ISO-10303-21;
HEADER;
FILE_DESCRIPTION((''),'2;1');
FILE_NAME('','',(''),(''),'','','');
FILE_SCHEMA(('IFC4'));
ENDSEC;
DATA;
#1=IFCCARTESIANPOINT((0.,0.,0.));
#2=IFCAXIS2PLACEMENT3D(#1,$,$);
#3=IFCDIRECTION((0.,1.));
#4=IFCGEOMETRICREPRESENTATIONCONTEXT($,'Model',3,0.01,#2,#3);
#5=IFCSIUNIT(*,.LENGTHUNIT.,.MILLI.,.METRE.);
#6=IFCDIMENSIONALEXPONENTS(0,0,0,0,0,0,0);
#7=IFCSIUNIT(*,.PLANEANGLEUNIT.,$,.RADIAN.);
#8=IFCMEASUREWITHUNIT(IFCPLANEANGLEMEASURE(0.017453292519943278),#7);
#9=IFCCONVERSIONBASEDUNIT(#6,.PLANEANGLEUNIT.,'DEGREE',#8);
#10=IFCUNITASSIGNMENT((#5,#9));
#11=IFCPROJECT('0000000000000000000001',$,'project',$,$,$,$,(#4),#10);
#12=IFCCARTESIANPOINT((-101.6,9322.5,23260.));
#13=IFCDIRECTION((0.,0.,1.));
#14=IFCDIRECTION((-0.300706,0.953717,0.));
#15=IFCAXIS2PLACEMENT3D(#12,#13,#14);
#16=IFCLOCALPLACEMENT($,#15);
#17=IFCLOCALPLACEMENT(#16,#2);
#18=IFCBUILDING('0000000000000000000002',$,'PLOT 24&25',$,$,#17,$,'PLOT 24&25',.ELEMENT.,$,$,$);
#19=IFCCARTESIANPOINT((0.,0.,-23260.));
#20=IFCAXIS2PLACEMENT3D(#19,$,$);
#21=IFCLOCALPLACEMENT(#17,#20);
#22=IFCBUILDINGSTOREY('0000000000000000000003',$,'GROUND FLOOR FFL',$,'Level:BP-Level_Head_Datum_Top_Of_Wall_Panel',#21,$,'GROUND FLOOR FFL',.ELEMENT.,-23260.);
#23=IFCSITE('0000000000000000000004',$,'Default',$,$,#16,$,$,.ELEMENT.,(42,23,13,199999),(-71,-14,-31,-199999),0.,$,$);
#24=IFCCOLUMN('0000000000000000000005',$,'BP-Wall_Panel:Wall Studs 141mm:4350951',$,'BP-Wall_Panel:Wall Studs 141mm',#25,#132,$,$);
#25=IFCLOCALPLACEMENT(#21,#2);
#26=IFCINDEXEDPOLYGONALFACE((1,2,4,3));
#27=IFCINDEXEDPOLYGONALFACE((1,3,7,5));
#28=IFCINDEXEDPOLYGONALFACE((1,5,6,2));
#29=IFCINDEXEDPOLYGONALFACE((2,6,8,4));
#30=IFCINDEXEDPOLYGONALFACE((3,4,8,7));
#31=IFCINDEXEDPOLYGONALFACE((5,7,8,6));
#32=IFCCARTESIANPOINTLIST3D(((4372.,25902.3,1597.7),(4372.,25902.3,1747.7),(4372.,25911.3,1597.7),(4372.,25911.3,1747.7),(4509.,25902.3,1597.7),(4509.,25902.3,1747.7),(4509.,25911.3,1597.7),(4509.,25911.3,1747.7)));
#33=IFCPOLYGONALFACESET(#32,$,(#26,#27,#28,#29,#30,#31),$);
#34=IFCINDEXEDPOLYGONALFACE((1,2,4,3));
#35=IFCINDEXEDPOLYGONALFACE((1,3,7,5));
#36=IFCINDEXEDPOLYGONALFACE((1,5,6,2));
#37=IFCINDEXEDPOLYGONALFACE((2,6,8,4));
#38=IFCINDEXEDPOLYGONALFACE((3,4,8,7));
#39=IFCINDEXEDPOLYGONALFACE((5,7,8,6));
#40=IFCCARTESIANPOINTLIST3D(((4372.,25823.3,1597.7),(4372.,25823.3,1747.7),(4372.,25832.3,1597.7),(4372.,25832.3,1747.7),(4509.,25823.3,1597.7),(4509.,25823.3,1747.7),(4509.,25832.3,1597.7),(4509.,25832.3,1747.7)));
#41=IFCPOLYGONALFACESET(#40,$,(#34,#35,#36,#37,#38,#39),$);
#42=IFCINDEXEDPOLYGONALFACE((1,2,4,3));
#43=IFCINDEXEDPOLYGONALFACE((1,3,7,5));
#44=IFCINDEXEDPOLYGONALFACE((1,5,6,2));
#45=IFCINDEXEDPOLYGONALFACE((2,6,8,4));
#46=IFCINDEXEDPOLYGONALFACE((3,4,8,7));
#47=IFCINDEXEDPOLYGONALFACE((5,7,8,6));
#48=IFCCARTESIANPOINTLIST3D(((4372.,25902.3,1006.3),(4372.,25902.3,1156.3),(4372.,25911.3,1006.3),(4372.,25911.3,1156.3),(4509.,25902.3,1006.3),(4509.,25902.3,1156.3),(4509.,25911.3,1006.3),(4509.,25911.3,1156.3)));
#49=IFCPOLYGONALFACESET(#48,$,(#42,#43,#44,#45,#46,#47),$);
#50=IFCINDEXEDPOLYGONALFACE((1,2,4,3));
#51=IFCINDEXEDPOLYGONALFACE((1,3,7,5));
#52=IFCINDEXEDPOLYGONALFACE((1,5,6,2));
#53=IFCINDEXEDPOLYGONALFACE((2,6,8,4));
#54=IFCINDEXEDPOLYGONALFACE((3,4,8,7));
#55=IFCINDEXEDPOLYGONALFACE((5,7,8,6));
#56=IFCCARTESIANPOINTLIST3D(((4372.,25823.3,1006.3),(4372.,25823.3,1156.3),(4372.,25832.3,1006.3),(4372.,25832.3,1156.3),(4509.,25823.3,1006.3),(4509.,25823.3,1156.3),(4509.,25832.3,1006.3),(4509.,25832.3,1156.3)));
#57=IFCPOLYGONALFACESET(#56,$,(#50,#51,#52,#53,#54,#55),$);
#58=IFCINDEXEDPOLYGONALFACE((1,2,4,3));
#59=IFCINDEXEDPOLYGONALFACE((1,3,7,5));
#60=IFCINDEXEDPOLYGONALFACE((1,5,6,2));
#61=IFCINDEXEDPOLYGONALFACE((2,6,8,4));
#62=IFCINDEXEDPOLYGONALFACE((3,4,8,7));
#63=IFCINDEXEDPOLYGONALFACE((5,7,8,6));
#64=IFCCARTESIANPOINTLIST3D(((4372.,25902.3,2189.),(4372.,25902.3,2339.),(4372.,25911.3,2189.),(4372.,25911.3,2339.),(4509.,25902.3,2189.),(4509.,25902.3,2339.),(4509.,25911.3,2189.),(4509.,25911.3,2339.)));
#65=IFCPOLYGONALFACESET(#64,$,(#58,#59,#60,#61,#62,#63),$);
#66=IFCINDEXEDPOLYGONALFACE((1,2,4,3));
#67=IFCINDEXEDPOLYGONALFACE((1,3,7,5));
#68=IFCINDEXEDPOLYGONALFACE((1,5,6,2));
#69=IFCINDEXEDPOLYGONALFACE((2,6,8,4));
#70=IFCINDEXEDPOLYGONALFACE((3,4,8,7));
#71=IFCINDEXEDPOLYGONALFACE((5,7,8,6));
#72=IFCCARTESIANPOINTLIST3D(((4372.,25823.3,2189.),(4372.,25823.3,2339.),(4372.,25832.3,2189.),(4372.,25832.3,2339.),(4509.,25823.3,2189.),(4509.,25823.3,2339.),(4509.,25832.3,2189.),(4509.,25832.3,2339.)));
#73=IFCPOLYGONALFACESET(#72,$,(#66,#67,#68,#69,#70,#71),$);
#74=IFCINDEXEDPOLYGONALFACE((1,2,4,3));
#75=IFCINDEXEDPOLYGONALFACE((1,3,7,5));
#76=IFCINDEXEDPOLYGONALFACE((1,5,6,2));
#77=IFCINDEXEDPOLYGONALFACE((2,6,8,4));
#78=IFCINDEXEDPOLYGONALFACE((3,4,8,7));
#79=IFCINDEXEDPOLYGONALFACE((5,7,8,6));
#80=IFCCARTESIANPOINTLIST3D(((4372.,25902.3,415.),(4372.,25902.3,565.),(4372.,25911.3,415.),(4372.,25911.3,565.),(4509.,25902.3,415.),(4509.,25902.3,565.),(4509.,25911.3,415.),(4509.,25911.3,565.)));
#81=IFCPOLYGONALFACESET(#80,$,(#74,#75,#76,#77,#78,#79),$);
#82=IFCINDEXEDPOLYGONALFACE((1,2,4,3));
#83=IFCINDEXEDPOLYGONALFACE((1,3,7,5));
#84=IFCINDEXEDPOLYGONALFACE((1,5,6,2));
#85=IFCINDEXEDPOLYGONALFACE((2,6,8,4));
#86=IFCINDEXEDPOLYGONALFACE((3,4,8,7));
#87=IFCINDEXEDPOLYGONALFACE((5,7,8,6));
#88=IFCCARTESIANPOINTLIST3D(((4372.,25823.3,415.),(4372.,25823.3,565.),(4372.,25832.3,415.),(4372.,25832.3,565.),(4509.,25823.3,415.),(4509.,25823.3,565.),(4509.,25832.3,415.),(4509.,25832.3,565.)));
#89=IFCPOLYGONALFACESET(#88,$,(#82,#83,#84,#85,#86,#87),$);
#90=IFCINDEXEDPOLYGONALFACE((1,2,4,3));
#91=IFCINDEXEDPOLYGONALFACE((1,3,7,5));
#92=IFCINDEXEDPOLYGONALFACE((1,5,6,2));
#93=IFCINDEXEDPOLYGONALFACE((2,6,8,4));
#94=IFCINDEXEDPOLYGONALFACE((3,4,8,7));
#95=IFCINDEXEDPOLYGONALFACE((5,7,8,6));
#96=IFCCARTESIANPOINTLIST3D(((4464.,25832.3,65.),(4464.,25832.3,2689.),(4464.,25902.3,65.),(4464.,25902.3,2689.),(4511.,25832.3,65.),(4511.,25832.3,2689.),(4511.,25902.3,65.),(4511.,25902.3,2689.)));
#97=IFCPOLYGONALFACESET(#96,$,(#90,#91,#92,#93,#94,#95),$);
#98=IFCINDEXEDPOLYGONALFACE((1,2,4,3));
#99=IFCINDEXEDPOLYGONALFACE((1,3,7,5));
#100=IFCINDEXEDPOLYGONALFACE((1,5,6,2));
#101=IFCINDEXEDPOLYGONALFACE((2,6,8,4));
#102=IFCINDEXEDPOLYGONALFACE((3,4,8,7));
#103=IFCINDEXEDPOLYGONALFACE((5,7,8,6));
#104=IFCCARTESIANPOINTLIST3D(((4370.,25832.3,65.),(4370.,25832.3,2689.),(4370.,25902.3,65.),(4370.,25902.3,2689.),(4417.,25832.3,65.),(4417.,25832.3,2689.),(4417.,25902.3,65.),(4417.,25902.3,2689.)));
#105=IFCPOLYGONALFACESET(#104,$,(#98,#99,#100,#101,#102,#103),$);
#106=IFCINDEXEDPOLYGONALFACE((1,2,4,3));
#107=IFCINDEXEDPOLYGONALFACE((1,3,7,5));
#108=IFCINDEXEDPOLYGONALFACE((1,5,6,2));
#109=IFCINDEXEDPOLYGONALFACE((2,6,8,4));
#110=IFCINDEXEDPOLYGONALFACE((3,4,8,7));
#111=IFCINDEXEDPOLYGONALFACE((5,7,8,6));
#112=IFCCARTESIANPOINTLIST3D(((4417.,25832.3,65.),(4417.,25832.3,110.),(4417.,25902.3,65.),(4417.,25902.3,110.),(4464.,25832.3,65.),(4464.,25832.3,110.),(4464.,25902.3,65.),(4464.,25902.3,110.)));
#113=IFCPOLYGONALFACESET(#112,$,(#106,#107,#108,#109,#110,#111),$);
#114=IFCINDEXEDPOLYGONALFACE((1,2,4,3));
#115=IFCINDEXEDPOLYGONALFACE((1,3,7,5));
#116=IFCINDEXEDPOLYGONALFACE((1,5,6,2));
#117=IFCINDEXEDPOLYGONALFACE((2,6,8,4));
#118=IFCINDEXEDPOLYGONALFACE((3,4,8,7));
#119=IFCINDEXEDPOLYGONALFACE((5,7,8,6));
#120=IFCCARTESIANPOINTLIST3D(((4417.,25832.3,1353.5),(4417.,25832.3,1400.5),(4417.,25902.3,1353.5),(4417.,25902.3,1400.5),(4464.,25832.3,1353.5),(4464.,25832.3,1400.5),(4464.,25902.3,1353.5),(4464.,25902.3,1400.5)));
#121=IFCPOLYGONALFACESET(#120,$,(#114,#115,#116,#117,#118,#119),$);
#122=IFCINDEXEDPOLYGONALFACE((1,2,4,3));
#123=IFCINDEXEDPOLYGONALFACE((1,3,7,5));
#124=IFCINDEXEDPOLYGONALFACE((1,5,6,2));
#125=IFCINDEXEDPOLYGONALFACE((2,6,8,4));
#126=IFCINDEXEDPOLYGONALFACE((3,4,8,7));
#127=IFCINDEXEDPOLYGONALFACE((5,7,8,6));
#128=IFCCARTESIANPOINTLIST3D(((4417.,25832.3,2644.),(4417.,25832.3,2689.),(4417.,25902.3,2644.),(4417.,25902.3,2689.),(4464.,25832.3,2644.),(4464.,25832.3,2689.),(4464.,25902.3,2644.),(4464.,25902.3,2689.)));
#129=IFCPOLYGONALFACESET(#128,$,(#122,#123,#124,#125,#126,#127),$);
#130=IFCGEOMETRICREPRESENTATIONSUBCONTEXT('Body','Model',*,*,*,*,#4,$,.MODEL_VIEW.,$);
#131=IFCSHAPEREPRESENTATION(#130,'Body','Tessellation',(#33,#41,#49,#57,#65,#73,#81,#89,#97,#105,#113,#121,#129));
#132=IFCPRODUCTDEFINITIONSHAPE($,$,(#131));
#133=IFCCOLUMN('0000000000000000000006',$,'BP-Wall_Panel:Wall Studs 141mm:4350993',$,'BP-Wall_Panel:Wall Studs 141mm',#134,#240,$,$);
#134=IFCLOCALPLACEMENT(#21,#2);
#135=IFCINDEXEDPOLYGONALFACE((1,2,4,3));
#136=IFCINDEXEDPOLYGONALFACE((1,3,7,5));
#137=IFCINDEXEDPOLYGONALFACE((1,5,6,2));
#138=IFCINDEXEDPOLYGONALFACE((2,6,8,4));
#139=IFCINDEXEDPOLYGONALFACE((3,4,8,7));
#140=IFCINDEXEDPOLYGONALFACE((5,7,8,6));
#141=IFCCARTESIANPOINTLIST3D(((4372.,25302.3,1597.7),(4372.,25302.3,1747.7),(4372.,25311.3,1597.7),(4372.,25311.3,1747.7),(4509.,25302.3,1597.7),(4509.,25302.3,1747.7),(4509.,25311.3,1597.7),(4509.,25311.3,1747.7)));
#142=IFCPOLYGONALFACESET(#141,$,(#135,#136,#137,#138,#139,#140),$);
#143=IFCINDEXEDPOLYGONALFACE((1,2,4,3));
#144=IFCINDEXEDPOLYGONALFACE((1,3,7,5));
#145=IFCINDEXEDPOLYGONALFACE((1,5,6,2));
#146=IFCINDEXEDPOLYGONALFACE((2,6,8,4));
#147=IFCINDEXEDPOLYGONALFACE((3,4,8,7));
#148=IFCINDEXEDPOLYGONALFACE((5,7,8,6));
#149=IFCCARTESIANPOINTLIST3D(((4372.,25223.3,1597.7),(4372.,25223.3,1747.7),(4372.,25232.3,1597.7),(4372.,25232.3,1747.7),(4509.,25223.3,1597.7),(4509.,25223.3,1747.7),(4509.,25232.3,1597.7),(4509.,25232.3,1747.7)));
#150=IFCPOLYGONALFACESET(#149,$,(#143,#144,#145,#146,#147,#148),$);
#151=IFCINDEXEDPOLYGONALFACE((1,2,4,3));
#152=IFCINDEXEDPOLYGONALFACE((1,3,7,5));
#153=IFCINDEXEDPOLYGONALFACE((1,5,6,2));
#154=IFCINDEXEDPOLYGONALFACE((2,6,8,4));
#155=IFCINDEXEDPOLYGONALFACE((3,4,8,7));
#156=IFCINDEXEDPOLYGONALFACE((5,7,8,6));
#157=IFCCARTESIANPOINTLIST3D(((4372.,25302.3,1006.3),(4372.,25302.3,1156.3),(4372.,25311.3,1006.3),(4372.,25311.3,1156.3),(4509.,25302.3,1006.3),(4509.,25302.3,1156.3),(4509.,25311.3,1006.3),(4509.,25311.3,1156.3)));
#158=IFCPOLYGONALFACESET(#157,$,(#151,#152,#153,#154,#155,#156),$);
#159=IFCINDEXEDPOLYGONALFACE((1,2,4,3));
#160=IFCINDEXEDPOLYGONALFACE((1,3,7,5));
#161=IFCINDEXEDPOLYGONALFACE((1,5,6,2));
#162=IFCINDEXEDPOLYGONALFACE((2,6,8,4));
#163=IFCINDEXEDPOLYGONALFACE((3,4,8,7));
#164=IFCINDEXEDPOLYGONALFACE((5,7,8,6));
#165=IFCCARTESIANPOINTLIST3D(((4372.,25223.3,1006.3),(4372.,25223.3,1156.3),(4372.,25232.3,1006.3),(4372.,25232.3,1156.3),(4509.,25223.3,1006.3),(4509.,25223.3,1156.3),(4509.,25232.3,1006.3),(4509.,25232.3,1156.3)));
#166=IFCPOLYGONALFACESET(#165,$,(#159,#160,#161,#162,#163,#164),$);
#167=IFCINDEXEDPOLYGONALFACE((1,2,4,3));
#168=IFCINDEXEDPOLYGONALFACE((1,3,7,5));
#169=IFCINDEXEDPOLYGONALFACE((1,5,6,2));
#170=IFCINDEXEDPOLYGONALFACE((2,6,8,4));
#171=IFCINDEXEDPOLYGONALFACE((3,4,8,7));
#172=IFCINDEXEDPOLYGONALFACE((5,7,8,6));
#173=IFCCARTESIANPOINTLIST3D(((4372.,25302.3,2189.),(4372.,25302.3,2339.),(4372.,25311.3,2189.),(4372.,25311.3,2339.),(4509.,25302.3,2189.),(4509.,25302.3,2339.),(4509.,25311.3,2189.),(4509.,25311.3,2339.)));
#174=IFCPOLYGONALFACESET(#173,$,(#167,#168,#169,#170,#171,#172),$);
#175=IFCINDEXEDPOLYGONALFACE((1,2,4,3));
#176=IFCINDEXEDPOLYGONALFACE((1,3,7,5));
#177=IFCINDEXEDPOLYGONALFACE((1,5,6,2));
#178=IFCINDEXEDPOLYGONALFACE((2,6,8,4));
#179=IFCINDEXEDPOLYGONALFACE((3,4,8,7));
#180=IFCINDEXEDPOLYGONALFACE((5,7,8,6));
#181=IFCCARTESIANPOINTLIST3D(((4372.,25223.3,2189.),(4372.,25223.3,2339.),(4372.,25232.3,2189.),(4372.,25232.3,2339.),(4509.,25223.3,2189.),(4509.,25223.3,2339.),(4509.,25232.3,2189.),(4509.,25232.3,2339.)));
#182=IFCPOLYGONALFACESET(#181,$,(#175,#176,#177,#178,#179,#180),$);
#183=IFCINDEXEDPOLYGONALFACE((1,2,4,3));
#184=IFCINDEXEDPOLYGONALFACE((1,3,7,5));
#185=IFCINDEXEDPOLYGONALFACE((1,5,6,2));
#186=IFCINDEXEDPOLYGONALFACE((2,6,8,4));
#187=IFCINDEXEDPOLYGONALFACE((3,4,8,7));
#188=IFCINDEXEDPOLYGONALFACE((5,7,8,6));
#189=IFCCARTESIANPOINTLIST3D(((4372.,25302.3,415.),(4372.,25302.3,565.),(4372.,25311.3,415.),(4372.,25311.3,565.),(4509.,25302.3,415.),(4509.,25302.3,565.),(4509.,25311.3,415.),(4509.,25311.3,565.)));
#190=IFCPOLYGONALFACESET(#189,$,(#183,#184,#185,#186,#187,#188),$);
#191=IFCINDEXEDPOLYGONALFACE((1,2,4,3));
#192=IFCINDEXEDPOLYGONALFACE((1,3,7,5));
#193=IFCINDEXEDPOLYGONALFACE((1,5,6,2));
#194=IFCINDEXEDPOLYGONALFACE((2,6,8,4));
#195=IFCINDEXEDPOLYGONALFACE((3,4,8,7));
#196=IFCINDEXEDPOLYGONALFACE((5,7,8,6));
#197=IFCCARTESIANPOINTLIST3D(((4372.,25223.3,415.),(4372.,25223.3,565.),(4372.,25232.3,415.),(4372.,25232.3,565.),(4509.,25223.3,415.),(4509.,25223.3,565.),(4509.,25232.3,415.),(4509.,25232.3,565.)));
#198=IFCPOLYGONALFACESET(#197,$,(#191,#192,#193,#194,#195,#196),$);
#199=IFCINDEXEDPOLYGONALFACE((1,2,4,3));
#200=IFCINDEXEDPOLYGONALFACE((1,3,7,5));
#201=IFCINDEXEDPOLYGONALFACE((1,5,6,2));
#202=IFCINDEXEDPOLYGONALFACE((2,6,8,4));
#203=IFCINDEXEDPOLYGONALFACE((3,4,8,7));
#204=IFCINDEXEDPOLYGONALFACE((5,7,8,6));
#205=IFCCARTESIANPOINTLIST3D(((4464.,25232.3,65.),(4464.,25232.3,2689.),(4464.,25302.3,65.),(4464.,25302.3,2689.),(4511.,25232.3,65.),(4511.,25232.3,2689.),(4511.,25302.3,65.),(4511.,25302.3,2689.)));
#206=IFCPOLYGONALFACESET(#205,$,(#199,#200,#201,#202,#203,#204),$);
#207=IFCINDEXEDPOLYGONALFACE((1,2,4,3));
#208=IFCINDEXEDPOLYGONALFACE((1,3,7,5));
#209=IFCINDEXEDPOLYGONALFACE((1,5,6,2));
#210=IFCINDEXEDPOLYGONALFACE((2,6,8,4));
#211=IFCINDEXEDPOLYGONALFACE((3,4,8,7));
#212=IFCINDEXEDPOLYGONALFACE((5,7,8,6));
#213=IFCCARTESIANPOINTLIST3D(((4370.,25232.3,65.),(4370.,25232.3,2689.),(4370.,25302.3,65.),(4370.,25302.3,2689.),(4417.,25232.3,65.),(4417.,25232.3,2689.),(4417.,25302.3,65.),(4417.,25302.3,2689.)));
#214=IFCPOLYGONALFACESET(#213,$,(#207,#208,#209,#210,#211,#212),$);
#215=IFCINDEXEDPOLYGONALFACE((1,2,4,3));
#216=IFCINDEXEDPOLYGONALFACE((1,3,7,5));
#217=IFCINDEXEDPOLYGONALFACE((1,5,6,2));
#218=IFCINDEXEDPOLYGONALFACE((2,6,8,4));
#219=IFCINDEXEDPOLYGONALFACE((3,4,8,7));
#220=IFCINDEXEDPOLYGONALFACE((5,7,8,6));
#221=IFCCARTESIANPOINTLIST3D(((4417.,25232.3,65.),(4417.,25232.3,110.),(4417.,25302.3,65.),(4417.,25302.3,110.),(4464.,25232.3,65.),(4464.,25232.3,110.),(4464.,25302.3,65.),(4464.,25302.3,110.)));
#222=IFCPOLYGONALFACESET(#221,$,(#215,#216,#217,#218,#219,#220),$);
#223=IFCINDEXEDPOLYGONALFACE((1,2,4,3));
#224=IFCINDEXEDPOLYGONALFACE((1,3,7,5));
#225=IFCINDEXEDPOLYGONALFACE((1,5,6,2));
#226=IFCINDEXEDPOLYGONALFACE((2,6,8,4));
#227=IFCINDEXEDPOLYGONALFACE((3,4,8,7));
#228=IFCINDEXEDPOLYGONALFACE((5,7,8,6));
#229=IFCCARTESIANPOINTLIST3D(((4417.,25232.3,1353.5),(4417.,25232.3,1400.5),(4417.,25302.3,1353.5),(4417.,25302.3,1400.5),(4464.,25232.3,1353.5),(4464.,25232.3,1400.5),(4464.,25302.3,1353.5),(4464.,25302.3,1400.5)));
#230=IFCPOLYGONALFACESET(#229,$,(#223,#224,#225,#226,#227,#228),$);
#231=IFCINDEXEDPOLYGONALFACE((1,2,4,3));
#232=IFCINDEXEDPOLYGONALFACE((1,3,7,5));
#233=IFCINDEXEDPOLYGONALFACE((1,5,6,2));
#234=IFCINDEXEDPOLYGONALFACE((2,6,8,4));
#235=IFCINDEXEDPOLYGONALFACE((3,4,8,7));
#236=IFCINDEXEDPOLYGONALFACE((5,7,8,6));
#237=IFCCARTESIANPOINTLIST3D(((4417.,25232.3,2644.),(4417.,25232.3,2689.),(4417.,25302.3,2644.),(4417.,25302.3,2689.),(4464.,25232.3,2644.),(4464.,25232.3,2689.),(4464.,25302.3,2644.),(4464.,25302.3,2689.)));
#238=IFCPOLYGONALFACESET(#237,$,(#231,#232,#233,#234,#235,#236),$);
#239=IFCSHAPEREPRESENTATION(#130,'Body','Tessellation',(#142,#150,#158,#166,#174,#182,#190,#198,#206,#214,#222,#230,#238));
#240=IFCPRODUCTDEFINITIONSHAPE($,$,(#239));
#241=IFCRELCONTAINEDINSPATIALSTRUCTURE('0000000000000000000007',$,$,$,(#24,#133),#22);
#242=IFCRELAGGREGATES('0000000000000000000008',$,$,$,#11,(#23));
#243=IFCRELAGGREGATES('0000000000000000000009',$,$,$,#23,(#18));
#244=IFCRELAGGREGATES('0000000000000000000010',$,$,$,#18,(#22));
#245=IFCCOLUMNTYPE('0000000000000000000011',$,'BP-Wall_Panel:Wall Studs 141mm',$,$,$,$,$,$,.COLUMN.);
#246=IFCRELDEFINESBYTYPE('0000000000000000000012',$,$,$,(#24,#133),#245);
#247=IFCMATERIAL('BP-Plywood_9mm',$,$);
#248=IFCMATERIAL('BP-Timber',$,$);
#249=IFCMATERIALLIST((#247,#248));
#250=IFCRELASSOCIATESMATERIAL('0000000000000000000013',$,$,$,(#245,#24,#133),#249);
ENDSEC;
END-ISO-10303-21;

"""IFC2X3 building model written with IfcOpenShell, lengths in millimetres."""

from ifc_helpers import new_model, entity, si_unit, converted_unit, direction, frame, origin, origin_2d_with_axis, place, context, subcontext, project, spatial, rectangle, extrude, source, transform, mapped, material, material_list, type_object, type_shapes, element, save


model = new_model("IFC2X3")

# Units and contexts
model_context = context("Model", 3, precision=0.01, world=origin(), true_north=direction((0.0, 1.0)))
body_context = subcontext(model_context, "Body", "Model", "MODEL_VIEW")
ifc_project = project(units=[si_unit("LENGTHUNIT", "METRE", prefix="MILLI"), converted_unit("PLANEANGLEUNIT", "DEGREE", entity("IfcPlaneAngleMeasure", 0.017453292519943278), si_unit("PLANEANGLEUNIT", "RADIAN"), dimensions=[0, 0, 0, 0, 0, 0, 0])], contexts=[model_context])

# Site, building, storey
site_placement = place(None, frame((-101.6, 9322.5, 23260.0), z_axis=(0.0, 0.0, 1.0), x_axis=(-0.300706, 0.953717, 0.0)))
site = spatial("IfcSite", under=ifc_project, at=site_placement, Name="Default", CompositionType="ELEMENT", RefLatitude=(42, 23, 13, 199999), RefLongitude=(-71, -14, -31, -199999), RefElevation=0.0)
building_placement = place(site_placement, origin())
building = spatial("IfcBuilding", under=site, at=building_placement, Name="PLOT 24&25", LongName="PLOT 24&25", CompositionType="ELEMENT")
storey_placement = place(building_placement, frame((0.0, 0.0, -23260.0)))
storey = spatial("IfcBuildingStorey", under=building, at=storey_placement, Name="GROUND FLOOR FFL", ObjectType="Level:BP-Level_Head_Datum_Top_Of_Wall_Panel", LongName="GROUND FLOOR FFL", CompositionType="ELEMENT", Elevation=-23260.0)

# Columns
ifc_material_1 = material(Name="BP-Plywood_9mm")
ifc_material_2 = material(Name="BP-Timber")
ifc_material_list = material_list([ifc_material_1, ifc_material_2])
column_type_1 = type_object("IfcColumnType", Name="BP-Wall_Panel:Wall Studs 141mm", PredefinedType="COLUMN", material=ifc_material_list)
shared_shape_1 = source(origin(), body_context, "Body", "SweptSolid", [
    extrude(rectangle(XDim=137.0, YDim=9.0, at=origin_2d_with_axis()), frame((39.5, 0.0, -21662.3), z_axis=(0.0, 0.0, 1.0), x_axis=(0.0, -1.0, 0.0)), (0.0, 0.0, 1.0), 150.0),
    extrude(rectangle(XDim=9.0, YDim=137.0, at=origin_2d_with_axis()), frame((-39.5, 0.0, -21662.3), z_axis=(0.0, 0.0, 1.0), x_axis=(-1.0, 0.0, 0.0)), (0.0, 0.0, 1.0), 150.0),
    extrude(rectangle(XDim=137.0, YDim=9.0, at=origin_2d_with_axis()), frame((39.5, 0.0, -22253.7), z_axis=(0.0, 0.0, 1.0), x_axis=(0.0, -1.0, 0.0)), (0.0, 0.0, 1.0), 150.0),
    extrude(rectangle(XDim=9.0, YDim=137.0, at=origin_2d_with_axis()), frame((-39.5, 0.0, -22253.7), z_axis=(0.0, 0.0, 1.0), x_axis=(-1.0, 0.0, 0.0)), (0.0, 0.0, 1.0), 150.0),
    extrude(rectangle(XDim=137.0, YDim=9.0, at=origin_2d_with_axis()), frame((39.5, 0.0, -21071.0), z_axis=(0.0, 0.0, 1.0), x_axis=(0.0, -1.0, 0.0)), (0.0, 0.0, 1.0), 150.0),
    extrude(rectangle(XDim=9.0, YDim=137.0, at=origin_2d_with_axis()), frame((-39.5, 0.0, -21071.0), z_axis=(0.0, 0.0, 1.0), x_axis=(-1.0, 0.0, 0.0)), (0.0, 0.0, 1.0), 150.0),
    extrude(rectangle(XDim=137.0, YDim=9.0, at=origin_2d_with_axis()), frame((39.5, 0.0, -22845.0), z_axis=(0.0, 0.0, 1.0), x_axis=(0.0, -1.0, 0.0)), (0.0, 0.0, 1.0), 150.0),
    extrude(rectangle(XDim=9.0, YDim=137.0, at=origin_2d_with_axis()), frame((-39.5, 0.0, -22845.0), z_axis=(0.0, 0.0, 1.0), x_axis=(-1.0, 0.0, 0.0)), (0.0, 0.0, 1.0), 150.0),
    extrude(rectangle(XDim=70.0, YDim=47.0, at=origin_2d_with_axis()), frame((0.0, -47.0, -23195.0), z_axis=(0.0, 0.0, 1.0), x_axis=(-1.0, 0.0, 0.0)), (0.0, 0.0, 1.0), 2624.0),
    extrude(rectangle(XDim=70.0, YDim=47.0, at=origin_2d_with_axis()), frame((0.0, 47.0, -23195.0), z_axis=(0.0, 0.0, 1.0), x_axis=(-1.0, 0.0, 0.0)), (0.0, 0.0, 1.0), 2624.0),
    extrude(rectangle(XDim=47.0, YDim=70.0, at=origin_2d_with_axis()), frame((0.0, 0.0, -23195.0), z_axis=(0.0, 0.0, 1.0), x_axis=(0.0, -1.0, 0.0)), (0.0, 0.0, 1.0), 45.0),
    extrude(rectangle(XDim=47.0, YDim=70.0, at=origin_2d_with_axis()), frame((0.0, 0.0, -21906.5), z_axis=(0.0, 0.0, 1.0), x_axis=(0.0, -1.0, 0.0)), (0.0, 0.0, 1.0), 47.0),
    extrude(rectangle(XDim=47.0, YDim=70.0, at=origin_2d_with_axis()), frame((0.0, 0.0, -20616.0), z_axis=(0.0, 0.0, 1.0), x_axis=(0.0, -1.0, 0.0)), (0.0, 0.0, 1.0), 45.0),
])
type_shapes(column_type_1, [shared_shape_1])
for number, where, z_axis, x_axis, name in (
    (1, (4440.5, 25867.3, 23260.0), (0.0, 0.0, 1.0), (0.0, 1.0, 0.0), "BP-Wall_Panel:Wall Studs 141mm:4350951"),
    (2, (4440.5, 25267.3, 23260.0), (0.0, 0.0, 1.0), (0.0, 1.0, 0.0), "BP-Wall_Panel:Wall Studs 141mm:4350993"),
):
    element("IfcColumn", number, at=place(storey_placement, frame(where, z_axis=z_axis, x_axis=x_axis)), inside=storey, type_object=column_type_1, material=ifc_material_list, Name=name, ObjectType="BP-Wall_Panel:Wall Studs 141mm", context=body_context, shape_type="MappedRepresentation", body=[
        mapped(shared_shape_1, transform((0.0, 0.0, 0.0), scale=1.0)),
    ])

save(model, "model.ifc")
